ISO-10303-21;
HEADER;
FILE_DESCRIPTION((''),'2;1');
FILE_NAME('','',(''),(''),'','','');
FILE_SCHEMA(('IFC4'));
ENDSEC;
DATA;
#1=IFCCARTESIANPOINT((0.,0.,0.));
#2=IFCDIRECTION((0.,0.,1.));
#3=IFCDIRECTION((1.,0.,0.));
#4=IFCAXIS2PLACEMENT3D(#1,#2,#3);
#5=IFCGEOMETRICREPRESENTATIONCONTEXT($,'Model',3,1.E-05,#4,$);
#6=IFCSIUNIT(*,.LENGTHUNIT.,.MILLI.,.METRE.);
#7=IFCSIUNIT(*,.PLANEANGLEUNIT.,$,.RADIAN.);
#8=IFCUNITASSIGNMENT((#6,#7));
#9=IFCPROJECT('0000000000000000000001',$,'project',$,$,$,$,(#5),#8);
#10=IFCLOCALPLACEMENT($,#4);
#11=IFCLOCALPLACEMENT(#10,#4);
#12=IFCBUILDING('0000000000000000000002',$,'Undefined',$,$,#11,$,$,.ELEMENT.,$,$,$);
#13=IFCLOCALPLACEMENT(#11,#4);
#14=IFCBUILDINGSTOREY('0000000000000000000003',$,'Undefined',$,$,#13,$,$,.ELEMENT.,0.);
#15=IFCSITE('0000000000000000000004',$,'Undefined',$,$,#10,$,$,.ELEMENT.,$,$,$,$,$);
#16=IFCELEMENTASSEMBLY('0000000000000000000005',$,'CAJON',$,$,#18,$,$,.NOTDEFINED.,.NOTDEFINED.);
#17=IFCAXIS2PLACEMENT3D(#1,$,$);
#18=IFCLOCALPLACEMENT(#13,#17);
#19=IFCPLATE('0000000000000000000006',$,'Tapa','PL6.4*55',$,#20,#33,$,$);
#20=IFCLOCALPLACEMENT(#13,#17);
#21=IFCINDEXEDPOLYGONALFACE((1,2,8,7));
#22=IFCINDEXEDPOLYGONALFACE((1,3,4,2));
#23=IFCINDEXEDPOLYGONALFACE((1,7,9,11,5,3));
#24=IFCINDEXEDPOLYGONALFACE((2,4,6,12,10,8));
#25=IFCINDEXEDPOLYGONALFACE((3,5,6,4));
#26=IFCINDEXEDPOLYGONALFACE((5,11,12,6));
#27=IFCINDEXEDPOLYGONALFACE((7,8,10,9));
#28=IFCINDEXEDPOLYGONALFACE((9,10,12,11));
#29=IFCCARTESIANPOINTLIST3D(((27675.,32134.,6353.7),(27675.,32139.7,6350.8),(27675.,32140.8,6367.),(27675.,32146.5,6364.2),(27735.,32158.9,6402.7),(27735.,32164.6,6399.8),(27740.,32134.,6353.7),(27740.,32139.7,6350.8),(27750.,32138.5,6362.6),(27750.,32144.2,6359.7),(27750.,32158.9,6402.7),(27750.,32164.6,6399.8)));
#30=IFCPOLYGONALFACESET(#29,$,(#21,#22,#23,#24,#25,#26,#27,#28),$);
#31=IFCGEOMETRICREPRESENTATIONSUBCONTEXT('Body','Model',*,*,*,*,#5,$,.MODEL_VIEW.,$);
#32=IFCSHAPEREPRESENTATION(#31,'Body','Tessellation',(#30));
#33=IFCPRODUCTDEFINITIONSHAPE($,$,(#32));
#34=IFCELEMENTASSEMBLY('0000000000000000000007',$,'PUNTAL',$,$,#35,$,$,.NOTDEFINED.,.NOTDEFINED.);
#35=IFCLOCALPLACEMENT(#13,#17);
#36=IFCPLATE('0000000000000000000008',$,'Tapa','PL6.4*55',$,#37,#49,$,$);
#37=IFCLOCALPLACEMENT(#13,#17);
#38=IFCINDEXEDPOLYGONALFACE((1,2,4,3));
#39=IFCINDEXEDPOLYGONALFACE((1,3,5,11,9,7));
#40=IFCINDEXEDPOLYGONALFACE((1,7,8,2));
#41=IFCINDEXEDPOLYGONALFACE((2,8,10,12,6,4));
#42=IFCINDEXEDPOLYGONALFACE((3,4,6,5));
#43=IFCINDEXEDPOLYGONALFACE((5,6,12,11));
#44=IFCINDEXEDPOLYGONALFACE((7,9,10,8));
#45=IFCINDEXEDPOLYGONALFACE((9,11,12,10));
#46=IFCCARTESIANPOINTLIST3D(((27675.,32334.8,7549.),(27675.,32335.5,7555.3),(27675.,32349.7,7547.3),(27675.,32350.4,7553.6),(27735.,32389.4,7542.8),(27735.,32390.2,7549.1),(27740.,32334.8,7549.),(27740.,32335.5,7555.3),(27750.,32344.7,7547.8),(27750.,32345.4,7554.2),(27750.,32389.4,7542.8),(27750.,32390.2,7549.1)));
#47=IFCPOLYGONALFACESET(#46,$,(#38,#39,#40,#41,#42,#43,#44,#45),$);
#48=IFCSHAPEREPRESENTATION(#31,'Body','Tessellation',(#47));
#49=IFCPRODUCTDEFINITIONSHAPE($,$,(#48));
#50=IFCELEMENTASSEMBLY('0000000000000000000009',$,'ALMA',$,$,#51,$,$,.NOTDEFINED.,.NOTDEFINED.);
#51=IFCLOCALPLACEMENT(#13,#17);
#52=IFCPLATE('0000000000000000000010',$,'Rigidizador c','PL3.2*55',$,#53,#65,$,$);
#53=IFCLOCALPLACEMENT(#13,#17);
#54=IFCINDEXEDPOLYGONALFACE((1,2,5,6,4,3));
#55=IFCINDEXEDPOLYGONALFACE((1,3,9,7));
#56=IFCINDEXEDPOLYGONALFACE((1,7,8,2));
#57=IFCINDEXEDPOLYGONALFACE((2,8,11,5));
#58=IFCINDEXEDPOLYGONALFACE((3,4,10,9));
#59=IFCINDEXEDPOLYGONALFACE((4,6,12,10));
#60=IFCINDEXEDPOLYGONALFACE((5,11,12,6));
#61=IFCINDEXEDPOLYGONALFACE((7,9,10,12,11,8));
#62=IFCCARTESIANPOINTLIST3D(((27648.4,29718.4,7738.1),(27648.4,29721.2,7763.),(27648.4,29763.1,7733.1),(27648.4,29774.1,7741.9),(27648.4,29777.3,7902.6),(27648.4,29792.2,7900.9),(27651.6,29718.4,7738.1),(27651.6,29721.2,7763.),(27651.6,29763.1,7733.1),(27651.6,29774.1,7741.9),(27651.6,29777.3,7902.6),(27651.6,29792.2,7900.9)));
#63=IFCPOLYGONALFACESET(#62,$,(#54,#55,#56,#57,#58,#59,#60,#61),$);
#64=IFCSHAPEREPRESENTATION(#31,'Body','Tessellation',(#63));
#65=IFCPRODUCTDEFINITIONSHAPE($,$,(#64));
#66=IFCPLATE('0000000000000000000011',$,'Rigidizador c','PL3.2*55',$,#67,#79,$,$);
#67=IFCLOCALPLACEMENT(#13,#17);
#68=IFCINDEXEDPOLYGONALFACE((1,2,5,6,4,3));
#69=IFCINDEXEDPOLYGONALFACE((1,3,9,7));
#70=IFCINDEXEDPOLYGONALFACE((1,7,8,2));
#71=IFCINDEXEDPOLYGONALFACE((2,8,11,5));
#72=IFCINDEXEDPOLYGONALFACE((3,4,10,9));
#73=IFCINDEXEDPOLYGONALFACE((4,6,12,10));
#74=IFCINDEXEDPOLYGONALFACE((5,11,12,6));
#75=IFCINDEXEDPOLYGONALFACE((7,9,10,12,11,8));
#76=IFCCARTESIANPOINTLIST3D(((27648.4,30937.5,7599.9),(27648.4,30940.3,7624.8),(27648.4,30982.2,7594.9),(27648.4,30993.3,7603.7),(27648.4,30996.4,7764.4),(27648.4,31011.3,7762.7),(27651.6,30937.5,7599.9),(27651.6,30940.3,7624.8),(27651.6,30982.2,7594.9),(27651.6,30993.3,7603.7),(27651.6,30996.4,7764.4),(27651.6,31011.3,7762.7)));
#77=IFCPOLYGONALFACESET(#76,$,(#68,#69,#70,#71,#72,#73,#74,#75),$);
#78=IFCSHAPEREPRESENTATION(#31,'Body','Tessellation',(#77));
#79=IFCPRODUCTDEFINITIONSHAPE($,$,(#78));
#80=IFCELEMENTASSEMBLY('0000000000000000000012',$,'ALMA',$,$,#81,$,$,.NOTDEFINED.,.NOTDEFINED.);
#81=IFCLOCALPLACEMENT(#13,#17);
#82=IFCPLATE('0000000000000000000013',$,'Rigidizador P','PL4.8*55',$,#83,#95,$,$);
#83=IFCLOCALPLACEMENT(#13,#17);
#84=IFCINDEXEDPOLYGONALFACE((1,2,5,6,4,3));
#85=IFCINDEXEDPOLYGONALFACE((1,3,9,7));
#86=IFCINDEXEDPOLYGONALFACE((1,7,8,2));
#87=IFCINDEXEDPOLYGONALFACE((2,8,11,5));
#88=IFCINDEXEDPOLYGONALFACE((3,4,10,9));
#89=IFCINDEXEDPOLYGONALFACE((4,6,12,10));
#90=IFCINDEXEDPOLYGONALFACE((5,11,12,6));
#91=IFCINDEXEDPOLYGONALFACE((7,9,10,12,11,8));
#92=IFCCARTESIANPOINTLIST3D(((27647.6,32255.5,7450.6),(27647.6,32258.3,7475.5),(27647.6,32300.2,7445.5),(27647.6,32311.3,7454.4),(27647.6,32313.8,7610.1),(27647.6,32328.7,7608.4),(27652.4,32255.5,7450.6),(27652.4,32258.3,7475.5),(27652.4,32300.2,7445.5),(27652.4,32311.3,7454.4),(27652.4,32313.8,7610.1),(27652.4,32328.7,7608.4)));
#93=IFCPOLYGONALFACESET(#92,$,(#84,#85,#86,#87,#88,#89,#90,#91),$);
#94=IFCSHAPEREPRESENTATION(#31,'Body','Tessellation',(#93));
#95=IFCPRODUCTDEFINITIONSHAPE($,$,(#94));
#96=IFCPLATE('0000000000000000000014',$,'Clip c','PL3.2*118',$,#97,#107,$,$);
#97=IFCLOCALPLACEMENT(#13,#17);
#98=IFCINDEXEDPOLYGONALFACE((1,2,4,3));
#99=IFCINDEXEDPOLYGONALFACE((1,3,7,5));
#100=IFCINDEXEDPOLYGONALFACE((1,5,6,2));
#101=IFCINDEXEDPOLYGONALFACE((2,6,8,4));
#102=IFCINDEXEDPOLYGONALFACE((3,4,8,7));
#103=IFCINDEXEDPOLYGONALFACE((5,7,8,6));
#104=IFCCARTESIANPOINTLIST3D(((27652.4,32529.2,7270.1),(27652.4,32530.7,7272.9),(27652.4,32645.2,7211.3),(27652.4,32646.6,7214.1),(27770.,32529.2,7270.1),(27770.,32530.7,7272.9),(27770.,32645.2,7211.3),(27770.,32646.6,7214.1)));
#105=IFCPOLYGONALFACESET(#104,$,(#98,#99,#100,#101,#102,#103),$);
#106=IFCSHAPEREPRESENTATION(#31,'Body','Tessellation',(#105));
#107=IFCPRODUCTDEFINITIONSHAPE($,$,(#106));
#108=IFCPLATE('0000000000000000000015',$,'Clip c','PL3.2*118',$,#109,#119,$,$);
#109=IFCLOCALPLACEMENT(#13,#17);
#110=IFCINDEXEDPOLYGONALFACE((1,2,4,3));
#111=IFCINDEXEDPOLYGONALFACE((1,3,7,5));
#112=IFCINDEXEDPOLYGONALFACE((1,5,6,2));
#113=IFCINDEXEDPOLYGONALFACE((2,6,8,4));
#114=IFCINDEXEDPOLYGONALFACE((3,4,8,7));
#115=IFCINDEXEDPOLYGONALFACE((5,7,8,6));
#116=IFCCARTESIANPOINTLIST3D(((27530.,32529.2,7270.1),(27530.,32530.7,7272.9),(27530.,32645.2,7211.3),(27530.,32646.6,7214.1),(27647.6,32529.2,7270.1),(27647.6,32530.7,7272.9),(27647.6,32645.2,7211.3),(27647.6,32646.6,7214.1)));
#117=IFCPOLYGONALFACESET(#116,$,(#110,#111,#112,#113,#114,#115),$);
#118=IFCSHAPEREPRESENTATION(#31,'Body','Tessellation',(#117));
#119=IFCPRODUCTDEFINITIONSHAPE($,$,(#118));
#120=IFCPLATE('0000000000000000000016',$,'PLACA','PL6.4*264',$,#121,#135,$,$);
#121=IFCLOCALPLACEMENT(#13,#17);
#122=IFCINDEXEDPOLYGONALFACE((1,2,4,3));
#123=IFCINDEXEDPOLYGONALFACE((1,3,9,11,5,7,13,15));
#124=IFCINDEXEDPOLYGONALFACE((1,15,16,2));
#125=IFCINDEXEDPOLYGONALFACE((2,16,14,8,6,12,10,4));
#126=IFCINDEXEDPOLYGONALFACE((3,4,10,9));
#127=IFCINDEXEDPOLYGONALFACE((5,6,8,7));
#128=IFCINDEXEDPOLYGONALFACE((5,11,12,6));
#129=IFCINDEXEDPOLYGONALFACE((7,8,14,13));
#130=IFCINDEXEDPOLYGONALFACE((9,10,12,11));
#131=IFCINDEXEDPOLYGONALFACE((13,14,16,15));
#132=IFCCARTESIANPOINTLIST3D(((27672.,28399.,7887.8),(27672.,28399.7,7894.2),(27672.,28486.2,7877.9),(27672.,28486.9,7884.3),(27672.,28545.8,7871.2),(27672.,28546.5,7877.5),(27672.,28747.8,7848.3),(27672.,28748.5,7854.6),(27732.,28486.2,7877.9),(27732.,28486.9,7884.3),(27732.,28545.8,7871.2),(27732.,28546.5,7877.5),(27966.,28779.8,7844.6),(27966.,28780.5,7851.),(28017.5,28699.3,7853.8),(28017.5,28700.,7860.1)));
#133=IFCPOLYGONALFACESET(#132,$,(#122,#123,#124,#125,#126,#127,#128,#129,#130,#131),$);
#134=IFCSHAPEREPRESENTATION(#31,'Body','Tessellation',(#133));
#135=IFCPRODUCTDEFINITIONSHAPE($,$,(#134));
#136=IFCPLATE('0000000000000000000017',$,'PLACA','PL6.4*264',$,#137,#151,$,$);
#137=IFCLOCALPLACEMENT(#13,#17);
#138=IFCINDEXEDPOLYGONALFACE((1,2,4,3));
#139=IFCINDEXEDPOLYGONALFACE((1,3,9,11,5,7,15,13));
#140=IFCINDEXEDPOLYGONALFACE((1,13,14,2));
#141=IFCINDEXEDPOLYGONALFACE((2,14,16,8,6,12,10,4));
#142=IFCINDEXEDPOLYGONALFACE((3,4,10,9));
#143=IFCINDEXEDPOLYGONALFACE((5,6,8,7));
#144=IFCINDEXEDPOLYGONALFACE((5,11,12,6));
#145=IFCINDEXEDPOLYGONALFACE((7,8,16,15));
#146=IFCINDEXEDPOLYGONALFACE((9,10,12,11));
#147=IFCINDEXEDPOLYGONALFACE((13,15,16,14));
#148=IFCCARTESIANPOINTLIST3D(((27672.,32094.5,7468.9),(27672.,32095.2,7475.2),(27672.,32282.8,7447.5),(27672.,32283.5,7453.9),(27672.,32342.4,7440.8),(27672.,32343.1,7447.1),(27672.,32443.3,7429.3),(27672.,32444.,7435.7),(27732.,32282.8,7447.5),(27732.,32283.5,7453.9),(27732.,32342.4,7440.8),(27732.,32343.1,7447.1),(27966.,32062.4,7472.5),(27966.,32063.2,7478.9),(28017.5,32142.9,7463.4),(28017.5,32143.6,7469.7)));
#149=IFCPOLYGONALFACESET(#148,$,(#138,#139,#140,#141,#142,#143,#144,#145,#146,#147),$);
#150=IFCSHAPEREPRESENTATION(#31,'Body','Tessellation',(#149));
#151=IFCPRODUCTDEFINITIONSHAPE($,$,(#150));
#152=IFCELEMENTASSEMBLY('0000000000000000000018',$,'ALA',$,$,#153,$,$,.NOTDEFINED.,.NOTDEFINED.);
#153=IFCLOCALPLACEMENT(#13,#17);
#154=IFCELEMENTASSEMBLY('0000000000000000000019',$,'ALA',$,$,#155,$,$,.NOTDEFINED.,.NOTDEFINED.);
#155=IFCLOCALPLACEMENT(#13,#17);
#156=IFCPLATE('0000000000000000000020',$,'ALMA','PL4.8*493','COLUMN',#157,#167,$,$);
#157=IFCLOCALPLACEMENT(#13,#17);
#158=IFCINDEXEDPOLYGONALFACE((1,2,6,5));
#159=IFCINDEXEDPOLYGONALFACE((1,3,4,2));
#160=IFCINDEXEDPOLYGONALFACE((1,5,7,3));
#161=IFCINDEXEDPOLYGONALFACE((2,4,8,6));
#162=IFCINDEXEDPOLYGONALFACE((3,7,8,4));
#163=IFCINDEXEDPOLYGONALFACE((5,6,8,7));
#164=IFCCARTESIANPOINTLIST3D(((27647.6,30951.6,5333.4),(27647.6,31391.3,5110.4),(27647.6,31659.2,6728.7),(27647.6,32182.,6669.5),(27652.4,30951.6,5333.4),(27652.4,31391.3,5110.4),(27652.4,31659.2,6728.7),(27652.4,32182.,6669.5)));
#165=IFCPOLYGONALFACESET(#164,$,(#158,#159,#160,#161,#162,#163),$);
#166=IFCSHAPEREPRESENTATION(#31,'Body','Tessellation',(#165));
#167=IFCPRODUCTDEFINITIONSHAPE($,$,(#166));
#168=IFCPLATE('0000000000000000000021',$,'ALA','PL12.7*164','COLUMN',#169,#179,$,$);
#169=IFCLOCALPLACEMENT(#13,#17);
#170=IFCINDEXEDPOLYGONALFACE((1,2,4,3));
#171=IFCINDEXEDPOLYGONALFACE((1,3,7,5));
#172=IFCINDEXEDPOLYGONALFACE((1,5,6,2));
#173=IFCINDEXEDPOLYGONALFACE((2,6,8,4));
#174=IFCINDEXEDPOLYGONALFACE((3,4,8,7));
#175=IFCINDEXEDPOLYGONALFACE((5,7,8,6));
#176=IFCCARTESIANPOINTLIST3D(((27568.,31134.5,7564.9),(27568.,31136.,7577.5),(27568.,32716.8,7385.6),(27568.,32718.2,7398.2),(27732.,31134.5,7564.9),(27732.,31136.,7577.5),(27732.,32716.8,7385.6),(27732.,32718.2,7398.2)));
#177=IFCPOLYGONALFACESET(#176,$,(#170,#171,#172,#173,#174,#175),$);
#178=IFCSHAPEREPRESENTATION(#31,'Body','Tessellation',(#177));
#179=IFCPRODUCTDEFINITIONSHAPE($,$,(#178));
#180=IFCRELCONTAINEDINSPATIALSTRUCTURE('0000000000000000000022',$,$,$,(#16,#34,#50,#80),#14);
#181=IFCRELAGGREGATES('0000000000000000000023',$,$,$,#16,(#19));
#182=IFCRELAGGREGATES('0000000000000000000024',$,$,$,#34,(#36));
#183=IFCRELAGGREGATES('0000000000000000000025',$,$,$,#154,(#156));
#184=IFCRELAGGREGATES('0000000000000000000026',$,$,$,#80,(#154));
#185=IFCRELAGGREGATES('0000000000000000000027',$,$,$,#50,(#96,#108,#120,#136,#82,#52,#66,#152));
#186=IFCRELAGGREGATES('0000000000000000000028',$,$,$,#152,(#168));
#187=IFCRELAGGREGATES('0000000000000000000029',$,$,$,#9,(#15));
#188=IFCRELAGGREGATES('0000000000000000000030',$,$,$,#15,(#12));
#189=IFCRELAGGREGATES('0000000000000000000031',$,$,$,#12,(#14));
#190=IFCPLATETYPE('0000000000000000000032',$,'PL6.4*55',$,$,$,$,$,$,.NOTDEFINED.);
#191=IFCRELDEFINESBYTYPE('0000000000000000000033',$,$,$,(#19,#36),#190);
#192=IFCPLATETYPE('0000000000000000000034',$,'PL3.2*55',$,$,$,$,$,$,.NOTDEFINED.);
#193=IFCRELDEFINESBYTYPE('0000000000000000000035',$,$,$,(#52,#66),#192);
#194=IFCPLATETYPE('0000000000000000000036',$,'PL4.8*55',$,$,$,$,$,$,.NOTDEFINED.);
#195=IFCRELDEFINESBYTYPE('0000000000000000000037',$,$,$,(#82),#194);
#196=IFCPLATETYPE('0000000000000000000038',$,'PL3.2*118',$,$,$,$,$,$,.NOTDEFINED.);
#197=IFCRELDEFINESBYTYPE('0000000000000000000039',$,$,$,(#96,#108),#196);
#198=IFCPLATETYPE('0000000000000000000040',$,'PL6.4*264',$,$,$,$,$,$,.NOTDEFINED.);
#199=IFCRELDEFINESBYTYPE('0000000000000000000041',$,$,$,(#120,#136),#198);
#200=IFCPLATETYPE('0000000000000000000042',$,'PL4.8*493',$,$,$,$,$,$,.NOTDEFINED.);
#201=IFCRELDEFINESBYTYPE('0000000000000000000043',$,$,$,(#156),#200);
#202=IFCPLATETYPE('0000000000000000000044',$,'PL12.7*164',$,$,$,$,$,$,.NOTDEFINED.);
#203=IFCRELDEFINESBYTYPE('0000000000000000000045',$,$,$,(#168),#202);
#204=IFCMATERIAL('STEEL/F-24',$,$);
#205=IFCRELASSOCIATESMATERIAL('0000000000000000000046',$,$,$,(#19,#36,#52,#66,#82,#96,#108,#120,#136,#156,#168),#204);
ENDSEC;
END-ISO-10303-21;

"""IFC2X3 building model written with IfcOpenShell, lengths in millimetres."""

from ifc_helpers import new_model, si_unit, frame, origin_with_axes, place, context, subcontext, project, spatial, polyline, outline, extrude, boolean, clip, halfspace, material, type_object, element, aggregate, save


model = new_model("IFC2X3")

# Units and contexts
model_context = context("Model", 3, precision=1e-05, world=origin_with_axes())
body_context = subcontext(model_context, "Body", "Model", "MODEL_VIEW")
ifc_project = project(units=[si_unit("LENGTHUNIT", "METRE", prefix="MILLI"), si_unit("PLANEANGLEUNIT", "RADIAN")], contexts=[model_context])

# Site, building, storey
site_placement = place(None, origin_with_axes())
site = spatial("IfcSite", under=ifc_project, at=site_placement, Name="Undefined", CompositionType="ELEMENT")
building_placement = place(site_placement, origin_with_axes())
building = spatial("IfcBuilding", under=site, at=building_placement, Name="Undefined", CompositionType="ELEMENT")
storey_placement = place(building_placement, origin_with_axes())
storey = spatial("IfcBuildingStorey", under=building, at=storey_placement, Name="Undefined", CompositionType="ELEMENT", Elevation=0.0)

# Element assemblies, plates
assembly_1_placement = place(storey_placement, origin_with_axes())
assembly_1 = element("IfcElementAssembly", 1, at=assembly_1_placement, inside=storey, Name="CAJON", AssemblyPlace="NOTDEFINED", PredefinedType="NOTDEFINED")
ifc_material_1 = material(Name="STEEL/F-24")
plate_type_1 = type_object("IfcPlateType", Name="PL6.4*55", PredefinedType="NOTDEFINED")
plate_1_placement = place(assembly_1_placement, frame((27675.0, 32136.9, 6352.2), z_axis=(0.0, -0.891888, 0.452257), x_axis=(1.0, 0.0, 0.0)))
plate_1 = element("IfcPlate", 2, at=plate_1_placement, type_object=plate_type_1, material=ifc_material_1, Name="Tapa", Description="PL6.4*55", context=body_context, shape_type="SweptSolid", body=[
    extrude(outline(polyline([(0.0, 0.0), (65.0, 0.0), (75.0, 10.0), (75.0, 55.0), (60.0, 55.0), (0.0, 15.0), (0.0, 0.0)])), frame((0.0, 0.0, -3.2), z_axis=(0.0, 0.0, 1.0), x_axis=(1.0, 0.0, 0.0)), (0.0, 0.0, 1.0), 6.4),
])
aggregate(assembly_1, [plate_1])
assembly_2_placement = place(storey_placement, origin_with_axes())
assembly_2 = element("IfcElementAssembly", 3, at=assembly_2_placement, inside=storey, Name="PUNTAL", AssemblyPlace="NOTDEFINED", PredefinedType="NOTDEFINED")
plate_2_placement = place(assembly_2_placement, frame((27675.0, 32335.1, 7552.1), z_axis=(0.0, 0.112644, 0.993635), x_axis=(1.0, 0.0, 0.0)))
plate_2 = element("IfcPlate", 4, at=plate_2_placement, type_object=plate_type_1, material=ifc_material_1, Name="Tapa", Description="PL6.4*55", context=body_context, shape_type="SweptSolid", body=[
    extrude(outline(polyline([(0.0, 0.0), (65.0, 0.0), (75.0, 10.0), (75.0, 55.0), (60.0, 55.0), (0.0, 15.0), (0.0, 0.0)])), frame((0.0, 0.0, -3.2), z_axis=(0.0, 0.0, 1.0), x_axis=(1.0, 0.0, 0.0)), (0.0, 0.0, 1.0), 6.4),
])
aggregate(assembly_2, [plate_2])

# Element assembly, plates
assembly_3_placement = place(storey_placement, origin_with_axes())
assembly_3 = element("IfcElementAssembly", 5, at=assembly_3_placement, inside=storey, Name="ALMA", AssemblyPlace="NOTDEFINED", PredefinedType="NOTDEFINED")
plate_type_2 = type_object("IfcPlateType", Name="PL3.2*55", PredefinedType="NOTDEFINED")
plate_3_placement = place(assembly_3_placement, frame((27650.0, 29792.2, 7900.9), z_axis=(1.0, 0.0, 0.0), x_axis=(0.0, -0.993635, 0.112644)))
plate_3 = element("IfcPlate", 6, at=plate_3_placement, type_object=plate_type_2, material=ifc_material_1, Name="Rigidizador c", Description="PL3.2*55", context=body_context, shape_type="SweptSolid", body=[
    extrude(outline(polyline([(0.0, 0.0), (15.0, 0.0), (55.0, 145.0), (55.0, 170.1), (10.0, 170.0), (0.0, 160.0), (0.0, 0.0)])), frame((0.0, 0.0, -1.6), z_axis=(0.0, 0.0, 1.0), x_axis=(1.0, 0.0, 0.0)), (0.0, 0.0, 1.0), 3.2),
])
plate_4_placement = place(assembly_3_placement, frame((27650.0, 31011.3, 7762.7), z_axis=(1.0, 0.0, 0.0), x_axis=(0.0, -0.993635, 0.112644)))
plate_4 = element("IfcPlate", 7, at=plate_4_placement, type_object=plate_type_2, material=ifc_material_1, Name="Rigidizador c", Description="PL3.2*55", context=body_context, shape_type="SweptSolid", body=[
    extrude(outline(polyline([(0.0, 0.0), (15.0, 0.0), (55.0, 145.0), (55.0, 170.1), (10.0, 170.0), (0.0, 160.0), (0.0, 0.0)])), frame((0.0, 0.0, -1.6), z_axis=(0.0, 0.0, 1.0), x_axis=(1.0, 0.0, 0.0)), (0.0, 0.0, 1.0), 3.2),
])

# Element assembly
assembly_4_placement = place(storey_placement, origin_with_axes())
assembly_4 = element("IfcElementAssembly", 8, at=assembly_4_placement, inside=storey, Name="ALMA", AssemblyPlace="NOTDEFINED", PredefinedType="NOTDEFINED")
plate_type_3 = type_object("IfcPlateType", Name="PL4.8*55", PredefinedType="NOTDEFINED")

# Plates
plate_5_placement = place(assembly_3_placement, frame((27650.0, 32328.7, 7608.4), z_axis=(1.0, 0.0, 0.0), x_axis=(0.0, -0.993635, 0.112644)))
plate_5 = element("IfcPlate", 9, at=plate_5_placement, type_object=plate_type_3, material=ifc_material_1, Name="Rigidizador P", Description="PL4.8*55", context=body_context, shape_type="SweptSolid", body=[
    extrude(outline(polyline([(0.0, 0.0), (15.0, 0.0), (55.0, 140.0), (55.0, 165.0), (10.0, 165.0), (0.0, 155.0), (0.0, 0.0)])), frame((0.0, 0.0, -2.4), z_axis=(0.0, 0.0, 1.0), x_axis=(1.0, 0.0, 0.0)), (0.0, 0.0, 1.0), 4.8),
])
plate_type_4 = type_object("IfcPlateType", Name="PL3.2*118", PredefinedType="NOTDEFINED")
plate_6_placement = place(assembly_3_placement, frame((27652.4, 32645.9, 7212.7), z_axis=(0.0, 0.452207, 0.891913), x_axis=(0.0, -0.891913, 0.452207)))
plate_6 = element("IfcPlate", 10, at=plate_6_placement, type_object=plate_type_4, material=ifc_material_1, Name="Clip c", Description="PL3.2*118", context=body_context, shape_type="SweptSolid", body=[
    extrude(outline(polyline([(0.0, 0.0), (130.0, 0.0), (130.0, 117.6), (0.0, 117.6), (0.0, 0.0)])), frame((0.0, 0.0, -1.6), z_axis=(0.0, 0.0, 1.0), x_axis=(1.0, 0.0, 0.0)), (0.0, 0.0, 1.0), 3.2),
])
plate_7_placement = place(assembly_3_placement, frame((27647.6, 32645.9, 7212.7), z_axis=(0.0, -0.452207, -0.891913), x_axis=(0.0, -0.891913, 0.452207)))
plate_7 = element("IfcPlate", 11, at=plate_7_placement, type_object=plate_type_4, material=ifc_material_1, Name="Clip c", Description="PL3.2*118", context=body_context, shape_type="SweptSolid", body=[
    extrude(outline(polyline([(0.0, 0.0), (130.0, 0.0), (130.0, 117.6), (0.0, 117.6), (0.0, 0.0)])), frame((0.0, 0.0, -1.6), z_axis=(0.0, 0.0, 1.0), x_axis=(1.0, 0.0, 0.0)), (0.0, 0.0, 1.0), 3.2),
])
plate_type_5 = type_object("IfcPlateType", Name="PL6.4*264", PredefinedType="NOTDEFINED")
plate_8_placement = place(assembly_3_placement, frame((27672.0, 28748.1, 7851.4), z_axis=(-0.000011, 0.112712, 0.993628), x_axis=(0.0, -0.993628, 0.112712)))
plate_8 = element("IfcPlate", 12, at=plate_8_placement, type_object=plate_type_5, material=ifc_material_1, Name="PLACA", Description="PL6.4*264", context=body_context, shape_type="CSG", body=[
    boolean("DIFFERENCE", extrude(outline(polyline([(0.0, 0.0), (351.0, 0.0), (48.8, 345.5), (-32.2, 294.0), (0.0, 0.0)])), frame((0.0, 0.0, -3.2), z_axis=(0.0, 0.0, 1.0), x_axis=(1.0, 0.0, 0.0)), (0.0, 0.0, 1.0), 6.4), extrude(outline(polyline([(0.0, 0.0), (60.0, 0.0), (60.0, 60.0), (0.0, 60.0), (0.0, 0.0)])), frame((203.3, 0.0, 5.0), z_axis=(-0.000317, -0.000011, -1.0), x_axis=(0.0, 1.0, -0.000011)), (0.0, 0.0, 1.0), 12.0)),
])
plate_9_placement = place(assembly_3_placement, frame((27672.0, 32443.6, 7432.5), z_axis=(-0.00001, 0.112706, 0.993628), x_axis=(0.0, -0.993628, 0.112706)))
plate_9 = element("IfcPlate", 13, at=plate_9_placement, type_object=plate_type_5, material=ifc_material_1, Name="PLACA", Description="PL6.4*264", context=body_context, shape_type="CSG", body=[
    boolean("DIFFERENCE", extrude(outline(polyline([(0.0, 0.0), (351.0, 0.0), (383.3, 294.0), (302.3, 345.5), (0.0, 0.0)])), frame((0.0, 0.0, -3.2), z_axis=(0.0, 0.0, 1.0), x_axis=(1.0, 0.0, 0.0)), (0.0, 0.0, 1.0), 6.4), extrude(outline(polyline([(0.0, 0.0), (60.0, 0.0), (60.0, 60.0), (0.0, 60.0), (0.0, 0.0)])), frame((101.5, 0.0, 5.0), z_axis=(-0.000311, -0.00001, -1.0), x_axis=(0.0, 1.0, -0.00001)), (0.0, 0.0, 1.0), 12.0)),
])

# Element assemblies, plate
assembly_5_placement = place(assembly_3_placement, origin_with_axes())
assembly_5 = element("IfcElementAssembly", 14, at=assembly_5_placement, Name="ALA", AssemblyPlace="NOTDEFINED", PredefinedType="NOTDEFINED")
assembly_6_placement = place(assembly_4_placement, origin_with_axes())
assembly_6 = element("IfcElementAssembly", 15, at=assembly_6_placement, Name="ALA", AssemblyPlace="NOTDEFINED", PredefinedType="NOTDEFINED")
plate_type_6 = type_object("IfcPlateType", Name="PL4.8*493", PredefinedType="NOTDEFINED")
plate_10_placement = place(assembly_6_placement, frame((27650.0, 31171.5, 5221.9), z_axis=(1.0, 0.0, 0.0), x_axis=(0.0, 0.452293, 0.891869)))
plate_10 = element("IfcPlate", 16, at=plate_10_placement, type_object=plate_type_6, material=ifc_material_1, Name="ALMA", Description="PL4.8*493", ObjectType="COLUMN", context=body_context, shape_type="Clipping", body=[
    clip(extrude(outline(polyline([(0.0, -246.5), (0.0, 246.5), (1748.1, 246.5), (1748.1, -246.5), (0.0, -246.5)])), frame((0.0, 0.0, -2.4), z_axis=(0.0, 0.0, 1.0), x_axis=(1.0, 0.0, 0.0)), (0.0, 0.0, 1.0), 4.8), halfspace(frame((1656.3, 0.0, 0.0), z_axis=(-0.93714, -0.348953, 0.0), x_axis=(0.0, 0.0, -1.0)), True)),
])
aggregate(assembly_6, [plate_10])

# Plate
plate_type_7 = type_object("IfcPlateType", Name="PL12.7*164", PredefinedType="NOTDEFINED")
plate_11_placement = place(assembly_5_placement, frame((27650.0, 31135.3, 7571.2), z_axis=(0.0, -0.11264, -0.993636), x_axis=(0.0, 0.993636, -0.11264)))
plate_11 = element("IfcPlate", 17, at=plate_11_placement, type_object=plate_type_7, material=ifc_material_1, Name="ALA", Description="PL12.7*164", ObjectType="COLUMN", context=body_context, shape_type="SweptSolid", body=[
    extrude(outline(polyline([(0.0, -82.0), (0.0, 82.0), (1592.4, 82.0), (1592.4, -82.0), (0.0, -82.0)])), frame((0.0, 0.0, -6.3), z_axis=(0.0, 0.0, 1.0), x_axis=(1.0, 0.0, 0.0)), (0.0, 0.0, 1.0), 12.7),
])

aggregate(assembly_4, [assembly_6])
aggregate(assembly_3, [plate_6, plate_7, plate_8, plate_9, plate_5, plate_3, plate_4, assembly_5])
aggregate(assembly_5, [plate_11])

save(model, "model.ifc")
